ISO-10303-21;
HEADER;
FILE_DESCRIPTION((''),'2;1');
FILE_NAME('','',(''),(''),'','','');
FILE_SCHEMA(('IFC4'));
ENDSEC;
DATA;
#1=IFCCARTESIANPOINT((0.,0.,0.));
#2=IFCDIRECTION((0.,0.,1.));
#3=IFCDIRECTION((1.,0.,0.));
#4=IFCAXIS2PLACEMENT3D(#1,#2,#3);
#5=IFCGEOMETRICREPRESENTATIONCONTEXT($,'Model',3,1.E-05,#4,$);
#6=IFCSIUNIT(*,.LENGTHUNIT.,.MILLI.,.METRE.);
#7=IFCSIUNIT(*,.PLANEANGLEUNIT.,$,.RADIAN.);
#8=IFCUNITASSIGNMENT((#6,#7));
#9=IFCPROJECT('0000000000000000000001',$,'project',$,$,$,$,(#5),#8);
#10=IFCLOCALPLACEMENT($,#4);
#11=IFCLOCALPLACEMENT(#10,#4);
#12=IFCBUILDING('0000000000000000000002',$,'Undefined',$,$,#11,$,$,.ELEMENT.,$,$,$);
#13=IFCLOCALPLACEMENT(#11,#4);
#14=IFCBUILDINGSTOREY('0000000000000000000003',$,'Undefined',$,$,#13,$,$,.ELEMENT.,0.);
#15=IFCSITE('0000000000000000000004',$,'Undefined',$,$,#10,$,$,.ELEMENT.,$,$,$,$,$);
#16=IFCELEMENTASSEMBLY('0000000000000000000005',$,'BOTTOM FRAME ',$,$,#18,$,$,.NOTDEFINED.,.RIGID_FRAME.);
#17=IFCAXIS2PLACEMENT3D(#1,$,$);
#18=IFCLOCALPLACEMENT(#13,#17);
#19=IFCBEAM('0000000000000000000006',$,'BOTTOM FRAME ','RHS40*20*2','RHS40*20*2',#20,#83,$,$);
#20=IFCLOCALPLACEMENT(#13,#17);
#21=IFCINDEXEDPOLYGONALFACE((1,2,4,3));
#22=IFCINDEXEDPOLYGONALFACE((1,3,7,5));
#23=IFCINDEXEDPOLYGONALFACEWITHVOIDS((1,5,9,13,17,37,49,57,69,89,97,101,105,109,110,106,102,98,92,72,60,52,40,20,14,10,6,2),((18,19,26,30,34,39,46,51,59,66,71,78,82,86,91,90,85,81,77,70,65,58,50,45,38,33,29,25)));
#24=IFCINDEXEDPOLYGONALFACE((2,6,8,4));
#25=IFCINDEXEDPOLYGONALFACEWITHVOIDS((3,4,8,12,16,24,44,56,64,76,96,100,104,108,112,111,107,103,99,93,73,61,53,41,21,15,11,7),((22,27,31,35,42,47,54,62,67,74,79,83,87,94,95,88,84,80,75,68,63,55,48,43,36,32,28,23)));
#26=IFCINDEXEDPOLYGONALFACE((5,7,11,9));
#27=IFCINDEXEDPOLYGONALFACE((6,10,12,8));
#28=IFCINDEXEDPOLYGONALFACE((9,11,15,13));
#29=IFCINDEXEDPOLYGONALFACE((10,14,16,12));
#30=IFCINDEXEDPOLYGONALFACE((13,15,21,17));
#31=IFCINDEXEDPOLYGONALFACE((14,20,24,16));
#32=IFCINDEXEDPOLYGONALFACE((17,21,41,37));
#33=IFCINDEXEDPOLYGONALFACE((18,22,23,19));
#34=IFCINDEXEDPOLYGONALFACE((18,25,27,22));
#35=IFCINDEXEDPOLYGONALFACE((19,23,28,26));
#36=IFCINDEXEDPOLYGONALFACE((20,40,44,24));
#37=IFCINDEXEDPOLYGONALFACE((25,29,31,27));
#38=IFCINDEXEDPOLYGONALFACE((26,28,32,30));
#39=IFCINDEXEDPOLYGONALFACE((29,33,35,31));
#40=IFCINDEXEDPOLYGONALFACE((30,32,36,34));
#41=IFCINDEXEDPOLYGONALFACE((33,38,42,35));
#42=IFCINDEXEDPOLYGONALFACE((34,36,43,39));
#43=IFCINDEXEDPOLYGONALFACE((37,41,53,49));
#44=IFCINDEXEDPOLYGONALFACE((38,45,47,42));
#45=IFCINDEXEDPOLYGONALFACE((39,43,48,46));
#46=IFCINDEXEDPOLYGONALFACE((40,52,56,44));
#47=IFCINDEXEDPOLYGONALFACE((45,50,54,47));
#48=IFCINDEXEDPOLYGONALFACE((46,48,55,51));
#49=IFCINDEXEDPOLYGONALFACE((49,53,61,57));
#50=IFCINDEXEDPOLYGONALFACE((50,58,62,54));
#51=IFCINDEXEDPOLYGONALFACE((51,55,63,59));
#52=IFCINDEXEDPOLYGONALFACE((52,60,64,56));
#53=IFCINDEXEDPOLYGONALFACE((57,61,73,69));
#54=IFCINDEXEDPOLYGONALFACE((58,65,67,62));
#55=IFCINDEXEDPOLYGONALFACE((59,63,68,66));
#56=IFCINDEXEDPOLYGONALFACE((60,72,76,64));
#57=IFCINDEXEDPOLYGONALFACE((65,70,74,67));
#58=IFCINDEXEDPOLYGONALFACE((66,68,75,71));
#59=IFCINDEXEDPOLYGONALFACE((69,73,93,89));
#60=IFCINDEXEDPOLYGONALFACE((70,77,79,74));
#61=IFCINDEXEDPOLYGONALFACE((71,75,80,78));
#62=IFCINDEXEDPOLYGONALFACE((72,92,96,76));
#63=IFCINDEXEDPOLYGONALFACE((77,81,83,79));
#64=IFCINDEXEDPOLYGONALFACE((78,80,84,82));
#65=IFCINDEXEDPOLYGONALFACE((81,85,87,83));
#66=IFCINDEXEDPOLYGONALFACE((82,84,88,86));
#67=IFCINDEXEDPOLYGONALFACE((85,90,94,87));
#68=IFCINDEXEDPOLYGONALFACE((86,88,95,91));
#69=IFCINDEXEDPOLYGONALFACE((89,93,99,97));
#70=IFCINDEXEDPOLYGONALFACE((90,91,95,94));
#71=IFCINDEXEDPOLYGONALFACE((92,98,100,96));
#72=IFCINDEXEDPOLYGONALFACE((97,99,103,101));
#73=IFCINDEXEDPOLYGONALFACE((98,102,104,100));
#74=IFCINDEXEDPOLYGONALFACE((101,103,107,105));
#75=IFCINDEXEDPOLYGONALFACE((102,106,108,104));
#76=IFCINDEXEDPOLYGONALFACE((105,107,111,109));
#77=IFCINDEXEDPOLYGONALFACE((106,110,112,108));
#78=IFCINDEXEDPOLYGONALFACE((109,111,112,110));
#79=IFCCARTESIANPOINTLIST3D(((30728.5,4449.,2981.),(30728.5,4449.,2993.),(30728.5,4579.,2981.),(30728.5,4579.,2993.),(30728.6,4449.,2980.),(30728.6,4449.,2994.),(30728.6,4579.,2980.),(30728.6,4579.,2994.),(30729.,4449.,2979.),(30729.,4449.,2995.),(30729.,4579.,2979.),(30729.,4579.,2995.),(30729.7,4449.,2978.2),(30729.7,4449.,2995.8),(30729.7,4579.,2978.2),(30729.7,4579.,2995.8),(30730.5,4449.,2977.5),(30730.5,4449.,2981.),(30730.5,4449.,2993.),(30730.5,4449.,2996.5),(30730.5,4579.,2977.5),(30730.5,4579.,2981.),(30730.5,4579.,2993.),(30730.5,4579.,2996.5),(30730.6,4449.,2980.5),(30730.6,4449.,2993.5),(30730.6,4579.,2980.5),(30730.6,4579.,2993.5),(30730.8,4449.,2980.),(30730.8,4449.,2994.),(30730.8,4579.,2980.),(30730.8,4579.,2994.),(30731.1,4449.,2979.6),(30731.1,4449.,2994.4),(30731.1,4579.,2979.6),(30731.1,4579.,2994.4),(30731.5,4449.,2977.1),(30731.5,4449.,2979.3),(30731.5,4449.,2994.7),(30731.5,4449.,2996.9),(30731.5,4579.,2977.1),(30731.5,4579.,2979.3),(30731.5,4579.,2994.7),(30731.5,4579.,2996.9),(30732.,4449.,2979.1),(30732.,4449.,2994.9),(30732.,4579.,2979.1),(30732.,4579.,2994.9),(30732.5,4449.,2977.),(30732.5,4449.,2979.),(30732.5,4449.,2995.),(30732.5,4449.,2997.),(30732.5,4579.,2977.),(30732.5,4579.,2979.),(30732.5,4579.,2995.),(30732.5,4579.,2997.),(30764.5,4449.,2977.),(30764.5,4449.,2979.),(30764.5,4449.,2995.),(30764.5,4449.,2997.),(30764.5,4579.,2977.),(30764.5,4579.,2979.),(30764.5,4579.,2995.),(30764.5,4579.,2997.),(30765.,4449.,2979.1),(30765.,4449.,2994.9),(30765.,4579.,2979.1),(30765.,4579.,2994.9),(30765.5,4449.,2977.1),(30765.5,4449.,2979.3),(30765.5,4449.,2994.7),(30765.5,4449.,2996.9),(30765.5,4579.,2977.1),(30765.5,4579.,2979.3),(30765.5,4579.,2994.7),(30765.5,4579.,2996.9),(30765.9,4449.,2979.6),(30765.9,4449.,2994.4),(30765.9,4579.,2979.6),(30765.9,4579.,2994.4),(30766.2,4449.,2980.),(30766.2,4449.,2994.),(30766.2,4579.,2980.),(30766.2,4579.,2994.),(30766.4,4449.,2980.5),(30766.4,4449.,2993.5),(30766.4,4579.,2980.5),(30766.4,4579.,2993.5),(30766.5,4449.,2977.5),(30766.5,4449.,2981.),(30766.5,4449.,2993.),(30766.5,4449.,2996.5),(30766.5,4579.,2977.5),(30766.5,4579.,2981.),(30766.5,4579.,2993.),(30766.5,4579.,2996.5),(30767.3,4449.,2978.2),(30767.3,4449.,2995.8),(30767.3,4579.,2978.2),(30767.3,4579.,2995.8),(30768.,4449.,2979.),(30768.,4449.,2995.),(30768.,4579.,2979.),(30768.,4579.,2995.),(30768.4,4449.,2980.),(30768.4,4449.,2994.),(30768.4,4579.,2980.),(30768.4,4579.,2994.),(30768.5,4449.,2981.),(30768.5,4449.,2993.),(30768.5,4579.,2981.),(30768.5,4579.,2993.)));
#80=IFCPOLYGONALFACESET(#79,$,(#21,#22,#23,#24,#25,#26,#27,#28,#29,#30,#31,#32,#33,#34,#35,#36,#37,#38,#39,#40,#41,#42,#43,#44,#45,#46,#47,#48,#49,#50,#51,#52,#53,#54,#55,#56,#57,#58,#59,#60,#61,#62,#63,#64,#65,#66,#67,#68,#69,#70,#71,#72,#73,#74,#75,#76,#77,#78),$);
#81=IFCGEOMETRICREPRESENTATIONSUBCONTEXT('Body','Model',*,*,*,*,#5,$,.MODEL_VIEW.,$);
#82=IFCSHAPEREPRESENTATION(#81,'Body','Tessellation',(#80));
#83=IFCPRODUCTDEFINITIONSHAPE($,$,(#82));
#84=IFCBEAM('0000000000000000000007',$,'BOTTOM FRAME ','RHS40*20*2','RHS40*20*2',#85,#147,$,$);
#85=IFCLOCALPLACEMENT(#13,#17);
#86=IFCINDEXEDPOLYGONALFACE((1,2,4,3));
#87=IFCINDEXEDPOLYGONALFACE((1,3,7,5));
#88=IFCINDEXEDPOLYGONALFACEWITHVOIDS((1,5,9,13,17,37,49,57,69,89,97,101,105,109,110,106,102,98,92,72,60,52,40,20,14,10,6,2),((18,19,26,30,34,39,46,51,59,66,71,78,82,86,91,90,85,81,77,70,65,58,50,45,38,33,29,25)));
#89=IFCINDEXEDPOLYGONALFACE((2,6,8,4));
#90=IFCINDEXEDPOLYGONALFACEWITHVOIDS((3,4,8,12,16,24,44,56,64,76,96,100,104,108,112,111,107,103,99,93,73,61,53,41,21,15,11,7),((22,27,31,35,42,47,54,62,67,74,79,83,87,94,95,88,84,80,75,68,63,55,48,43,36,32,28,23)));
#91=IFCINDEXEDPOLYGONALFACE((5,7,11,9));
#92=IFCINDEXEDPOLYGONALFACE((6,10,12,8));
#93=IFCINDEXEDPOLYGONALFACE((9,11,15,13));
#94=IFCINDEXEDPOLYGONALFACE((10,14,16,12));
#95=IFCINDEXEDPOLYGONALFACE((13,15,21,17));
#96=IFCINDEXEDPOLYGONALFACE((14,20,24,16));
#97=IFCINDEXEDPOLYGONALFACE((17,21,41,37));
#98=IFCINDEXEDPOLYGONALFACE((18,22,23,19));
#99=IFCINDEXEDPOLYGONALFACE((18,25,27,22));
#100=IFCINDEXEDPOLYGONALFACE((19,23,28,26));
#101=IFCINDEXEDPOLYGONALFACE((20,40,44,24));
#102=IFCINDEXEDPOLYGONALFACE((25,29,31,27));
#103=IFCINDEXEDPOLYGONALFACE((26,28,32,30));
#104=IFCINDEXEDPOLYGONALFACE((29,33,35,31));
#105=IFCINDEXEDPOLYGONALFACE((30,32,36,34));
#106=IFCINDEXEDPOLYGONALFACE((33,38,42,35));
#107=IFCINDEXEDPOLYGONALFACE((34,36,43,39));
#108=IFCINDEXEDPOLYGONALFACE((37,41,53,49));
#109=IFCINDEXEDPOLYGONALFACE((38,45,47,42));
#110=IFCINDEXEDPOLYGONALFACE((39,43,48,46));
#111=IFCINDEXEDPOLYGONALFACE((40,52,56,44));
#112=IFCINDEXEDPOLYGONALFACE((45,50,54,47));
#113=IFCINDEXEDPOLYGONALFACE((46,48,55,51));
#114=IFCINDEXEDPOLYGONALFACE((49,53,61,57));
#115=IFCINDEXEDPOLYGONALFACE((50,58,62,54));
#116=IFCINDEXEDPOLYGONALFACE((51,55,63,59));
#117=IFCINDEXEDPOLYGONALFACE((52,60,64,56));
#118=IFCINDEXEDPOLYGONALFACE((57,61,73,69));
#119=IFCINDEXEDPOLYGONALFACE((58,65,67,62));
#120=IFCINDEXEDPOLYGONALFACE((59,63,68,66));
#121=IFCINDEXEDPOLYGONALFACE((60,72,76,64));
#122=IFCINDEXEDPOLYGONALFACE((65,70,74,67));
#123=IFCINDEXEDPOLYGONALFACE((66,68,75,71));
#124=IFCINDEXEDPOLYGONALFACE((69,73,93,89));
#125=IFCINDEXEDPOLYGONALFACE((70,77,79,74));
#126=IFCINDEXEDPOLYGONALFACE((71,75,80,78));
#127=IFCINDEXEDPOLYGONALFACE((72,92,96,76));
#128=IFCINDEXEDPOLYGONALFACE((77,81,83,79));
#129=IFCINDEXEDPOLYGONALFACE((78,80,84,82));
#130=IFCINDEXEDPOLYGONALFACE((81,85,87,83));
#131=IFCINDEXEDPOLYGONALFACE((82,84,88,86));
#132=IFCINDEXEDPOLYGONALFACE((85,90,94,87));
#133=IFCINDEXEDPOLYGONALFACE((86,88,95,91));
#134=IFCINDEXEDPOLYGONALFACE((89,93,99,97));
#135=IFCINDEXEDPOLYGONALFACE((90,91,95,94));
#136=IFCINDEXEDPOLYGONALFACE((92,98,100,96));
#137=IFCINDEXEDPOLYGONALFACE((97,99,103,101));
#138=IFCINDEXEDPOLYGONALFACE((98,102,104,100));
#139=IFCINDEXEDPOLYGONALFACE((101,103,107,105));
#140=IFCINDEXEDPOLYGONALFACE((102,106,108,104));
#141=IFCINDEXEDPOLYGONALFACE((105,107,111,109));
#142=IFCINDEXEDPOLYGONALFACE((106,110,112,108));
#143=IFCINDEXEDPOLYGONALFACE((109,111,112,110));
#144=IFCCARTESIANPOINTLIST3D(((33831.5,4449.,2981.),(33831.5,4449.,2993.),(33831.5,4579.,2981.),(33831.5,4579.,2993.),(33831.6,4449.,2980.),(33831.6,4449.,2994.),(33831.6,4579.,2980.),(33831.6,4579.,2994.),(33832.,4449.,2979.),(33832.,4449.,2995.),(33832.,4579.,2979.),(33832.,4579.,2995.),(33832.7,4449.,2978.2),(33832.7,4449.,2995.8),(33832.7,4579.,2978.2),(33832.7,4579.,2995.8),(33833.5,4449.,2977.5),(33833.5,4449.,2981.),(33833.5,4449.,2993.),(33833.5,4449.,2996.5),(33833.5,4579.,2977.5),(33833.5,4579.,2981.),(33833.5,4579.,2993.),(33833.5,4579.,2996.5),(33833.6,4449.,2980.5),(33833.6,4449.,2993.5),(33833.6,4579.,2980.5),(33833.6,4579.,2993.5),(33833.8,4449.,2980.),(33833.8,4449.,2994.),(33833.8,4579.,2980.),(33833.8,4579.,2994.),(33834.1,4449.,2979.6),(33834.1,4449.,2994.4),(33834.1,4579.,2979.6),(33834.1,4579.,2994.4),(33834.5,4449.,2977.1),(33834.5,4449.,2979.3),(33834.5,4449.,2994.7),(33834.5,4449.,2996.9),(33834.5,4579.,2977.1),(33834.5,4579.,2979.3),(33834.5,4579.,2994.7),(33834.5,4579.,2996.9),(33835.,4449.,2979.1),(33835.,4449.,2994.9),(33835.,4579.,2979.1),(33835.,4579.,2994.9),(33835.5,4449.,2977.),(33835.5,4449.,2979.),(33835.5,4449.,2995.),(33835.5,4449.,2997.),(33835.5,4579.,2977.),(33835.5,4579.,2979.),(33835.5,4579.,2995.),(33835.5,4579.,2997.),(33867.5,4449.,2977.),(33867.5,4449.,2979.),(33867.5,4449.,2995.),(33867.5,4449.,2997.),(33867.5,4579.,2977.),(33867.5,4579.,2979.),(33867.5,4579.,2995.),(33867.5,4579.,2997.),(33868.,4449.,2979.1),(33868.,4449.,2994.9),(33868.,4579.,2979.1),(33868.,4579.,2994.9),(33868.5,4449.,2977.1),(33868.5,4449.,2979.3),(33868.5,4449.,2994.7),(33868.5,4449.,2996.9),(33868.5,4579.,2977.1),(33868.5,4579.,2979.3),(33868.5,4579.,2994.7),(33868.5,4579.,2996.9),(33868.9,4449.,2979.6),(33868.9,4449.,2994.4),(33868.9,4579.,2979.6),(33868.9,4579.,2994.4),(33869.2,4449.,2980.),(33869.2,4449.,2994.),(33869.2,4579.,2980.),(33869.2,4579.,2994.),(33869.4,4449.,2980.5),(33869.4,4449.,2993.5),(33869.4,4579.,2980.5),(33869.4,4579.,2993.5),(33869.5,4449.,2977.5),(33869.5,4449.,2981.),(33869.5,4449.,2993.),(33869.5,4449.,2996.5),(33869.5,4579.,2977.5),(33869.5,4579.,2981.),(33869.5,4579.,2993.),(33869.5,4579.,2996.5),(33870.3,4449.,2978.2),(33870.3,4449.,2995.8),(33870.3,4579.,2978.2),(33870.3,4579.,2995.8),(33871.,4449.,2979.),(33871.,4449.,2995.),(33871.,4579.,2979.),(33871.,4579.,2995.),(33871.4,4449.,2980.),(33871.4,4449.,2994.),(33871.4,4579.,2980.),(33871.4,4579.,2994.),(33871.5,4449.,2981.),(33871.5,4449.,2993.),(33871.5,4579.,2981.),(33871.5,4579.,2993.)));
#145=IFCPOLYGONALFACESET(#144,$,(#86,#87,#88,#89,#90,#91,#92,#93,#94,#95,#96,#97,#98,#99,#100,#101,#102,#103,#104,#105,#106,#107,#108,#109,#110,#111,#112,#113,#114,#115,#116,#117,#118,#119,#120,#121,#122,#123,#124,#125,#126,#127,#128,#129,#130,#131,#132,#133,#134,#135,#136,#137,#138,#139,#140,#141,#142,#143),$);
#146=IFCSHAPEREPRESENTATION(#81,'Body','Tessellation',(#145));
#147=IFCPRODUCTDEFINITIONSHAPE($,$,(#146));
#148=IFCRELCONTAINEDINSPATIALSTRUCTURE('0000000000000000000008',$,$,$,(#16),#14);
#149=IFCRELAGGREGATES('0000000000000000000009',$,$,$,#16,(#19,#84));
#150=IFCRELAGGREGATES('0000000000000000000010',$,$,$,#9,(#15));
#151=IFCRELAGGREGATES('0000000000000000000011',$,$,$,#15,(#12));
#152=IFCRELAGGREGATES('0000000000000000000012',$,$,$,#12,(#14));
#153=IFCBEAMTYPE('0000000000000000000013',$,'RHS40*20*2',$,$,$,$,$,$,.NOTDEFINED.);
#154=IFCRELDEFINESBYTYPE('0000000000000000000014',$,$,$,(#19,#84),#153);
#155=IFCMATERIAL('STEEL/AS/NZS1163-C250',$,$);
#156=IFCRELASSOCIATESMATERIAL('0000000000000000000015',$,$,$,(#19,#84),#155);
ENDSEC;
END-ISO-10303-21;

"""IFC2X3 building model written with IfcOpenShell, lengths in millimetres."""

from ifc_helpers import new_model, si_unit, frame, origin_with_axes, origin_2d_with_axis, place, context, subcontext, project, spatial, hollow_rectangle, extrude, material, type_object, element, aggregate, save


model = new_model("IFC2X3")

# Units and contexts
model_context = context("Model", 3, precision=1e-05, world=origin_with_axes())
body_context = subcontext(model_context, "Body", "Model", "MODEL_VIEW")
ifc_project = project(units=[si_unit("LENGTHUNIT", "METRE", prefix="MILLI"), si_unit("PLANEANGLEUNIT", "RADIAN")], contexts=[model_context])

# Site, building, storey
site_placement = place(None, origin_with_axes())
site = spatial("IfcSite", under=ifc_project, at=site_placement, Name="Undefined", CompositionType="ELEMENT")
building_placement = place(site_placement, origin_with_axes())
building = spatial("IfcBuilding", under=site, at=building_placement, Name="Undefined", CompositionType="ELEMENT")
storey_placement = place(building_placement, origin_with_axes())
storey = spatial("IfcBuildingStorey", under=building, at=storey_placement, Name="Undefined", CompositionType="ELEMENT", Elevation=0.0)

# Element assembly, beams
assembly_1_placement = place(storey_placement, origin_with_axes())
assembly_1 = element("IfcElementAssembly", 1, at=assembly_1_placement, inside=storey, Name="BOTTOM FRAME ", AssemblyPlace="NOTDEFINED", PredefinedType="RIGID_FRAME")
ifc_material_1 = material(Name="STEEL/AS/NZS1163-C250")
beam_type_1 = type_object("IfcBeamType", Name="RHS40*20*2", PredefinedType="NOTDEFINED")
beam_1_placement = place(assembly_1_placement, frame((30748.5, 4579.0, 2987.0), z_axis=(1.0, 0.0, 0.0), x_axis=(0.0, -1.0, 0.0)))
beam_1 = element("IfcBeam", 2, at=beam_1_placement, type_object=beam_type_1, material=ifc_material_1, Name="BOTTOM FRAME ", Description="RHS40*20*2", ObjectType="RHS40*20*2", context=body_context, shape_type="SweptSolid", body=[
    extrude(hollow_rectangle(XDim=20.0, YDim=40.0, WallThickness=2.0, InnerFilletRadius=2.0, OuterFilletRadius=4.0, at=origin_2d_with_axis()), frame((130.0, 0.0, 0.0), z_axis=(-1.0, 0.0, 0.0), x_axis=(0.0, -1.0, 0.0)), (0.0, 0.0, 1.0), 130.0),
])
beam_2_placement = place(assembly_1_placement, frame((33851.5, 4579.0, 2987.0), z_axis=(-1.0, 0.0, 0.0), x_axis=(0.0, -1.0, 0.0)))
beam_2 = element("IfcBeam", 3, at=beam_2_placement, type_object=beam_type_1, material=ifc_material_1, Name="BOTTOM FRAME ", Description="RHS40*20*2", ObjectType="RHS40*20*2", context=body_context, shape_type="SweptSolid", body=[
    extrude(hollow_rectangle(XDim=20.0, YDim=40.0, WallThickness=2.0, InnerFilletRadius=2.0, OuterFilletRadius=4.0, at=origin_2d_with_axis()), frame((130.0, 0.0, 0.0), z_axis=(-1.0, 0.0, 0.0), x_axis=(0.0, -1.0, 0.0)), (0.0, 0.0, 1.0), 130.0),
])
aggregate(assembly_1, [beam_1, beam_2])

save(model, "model.ifc")
